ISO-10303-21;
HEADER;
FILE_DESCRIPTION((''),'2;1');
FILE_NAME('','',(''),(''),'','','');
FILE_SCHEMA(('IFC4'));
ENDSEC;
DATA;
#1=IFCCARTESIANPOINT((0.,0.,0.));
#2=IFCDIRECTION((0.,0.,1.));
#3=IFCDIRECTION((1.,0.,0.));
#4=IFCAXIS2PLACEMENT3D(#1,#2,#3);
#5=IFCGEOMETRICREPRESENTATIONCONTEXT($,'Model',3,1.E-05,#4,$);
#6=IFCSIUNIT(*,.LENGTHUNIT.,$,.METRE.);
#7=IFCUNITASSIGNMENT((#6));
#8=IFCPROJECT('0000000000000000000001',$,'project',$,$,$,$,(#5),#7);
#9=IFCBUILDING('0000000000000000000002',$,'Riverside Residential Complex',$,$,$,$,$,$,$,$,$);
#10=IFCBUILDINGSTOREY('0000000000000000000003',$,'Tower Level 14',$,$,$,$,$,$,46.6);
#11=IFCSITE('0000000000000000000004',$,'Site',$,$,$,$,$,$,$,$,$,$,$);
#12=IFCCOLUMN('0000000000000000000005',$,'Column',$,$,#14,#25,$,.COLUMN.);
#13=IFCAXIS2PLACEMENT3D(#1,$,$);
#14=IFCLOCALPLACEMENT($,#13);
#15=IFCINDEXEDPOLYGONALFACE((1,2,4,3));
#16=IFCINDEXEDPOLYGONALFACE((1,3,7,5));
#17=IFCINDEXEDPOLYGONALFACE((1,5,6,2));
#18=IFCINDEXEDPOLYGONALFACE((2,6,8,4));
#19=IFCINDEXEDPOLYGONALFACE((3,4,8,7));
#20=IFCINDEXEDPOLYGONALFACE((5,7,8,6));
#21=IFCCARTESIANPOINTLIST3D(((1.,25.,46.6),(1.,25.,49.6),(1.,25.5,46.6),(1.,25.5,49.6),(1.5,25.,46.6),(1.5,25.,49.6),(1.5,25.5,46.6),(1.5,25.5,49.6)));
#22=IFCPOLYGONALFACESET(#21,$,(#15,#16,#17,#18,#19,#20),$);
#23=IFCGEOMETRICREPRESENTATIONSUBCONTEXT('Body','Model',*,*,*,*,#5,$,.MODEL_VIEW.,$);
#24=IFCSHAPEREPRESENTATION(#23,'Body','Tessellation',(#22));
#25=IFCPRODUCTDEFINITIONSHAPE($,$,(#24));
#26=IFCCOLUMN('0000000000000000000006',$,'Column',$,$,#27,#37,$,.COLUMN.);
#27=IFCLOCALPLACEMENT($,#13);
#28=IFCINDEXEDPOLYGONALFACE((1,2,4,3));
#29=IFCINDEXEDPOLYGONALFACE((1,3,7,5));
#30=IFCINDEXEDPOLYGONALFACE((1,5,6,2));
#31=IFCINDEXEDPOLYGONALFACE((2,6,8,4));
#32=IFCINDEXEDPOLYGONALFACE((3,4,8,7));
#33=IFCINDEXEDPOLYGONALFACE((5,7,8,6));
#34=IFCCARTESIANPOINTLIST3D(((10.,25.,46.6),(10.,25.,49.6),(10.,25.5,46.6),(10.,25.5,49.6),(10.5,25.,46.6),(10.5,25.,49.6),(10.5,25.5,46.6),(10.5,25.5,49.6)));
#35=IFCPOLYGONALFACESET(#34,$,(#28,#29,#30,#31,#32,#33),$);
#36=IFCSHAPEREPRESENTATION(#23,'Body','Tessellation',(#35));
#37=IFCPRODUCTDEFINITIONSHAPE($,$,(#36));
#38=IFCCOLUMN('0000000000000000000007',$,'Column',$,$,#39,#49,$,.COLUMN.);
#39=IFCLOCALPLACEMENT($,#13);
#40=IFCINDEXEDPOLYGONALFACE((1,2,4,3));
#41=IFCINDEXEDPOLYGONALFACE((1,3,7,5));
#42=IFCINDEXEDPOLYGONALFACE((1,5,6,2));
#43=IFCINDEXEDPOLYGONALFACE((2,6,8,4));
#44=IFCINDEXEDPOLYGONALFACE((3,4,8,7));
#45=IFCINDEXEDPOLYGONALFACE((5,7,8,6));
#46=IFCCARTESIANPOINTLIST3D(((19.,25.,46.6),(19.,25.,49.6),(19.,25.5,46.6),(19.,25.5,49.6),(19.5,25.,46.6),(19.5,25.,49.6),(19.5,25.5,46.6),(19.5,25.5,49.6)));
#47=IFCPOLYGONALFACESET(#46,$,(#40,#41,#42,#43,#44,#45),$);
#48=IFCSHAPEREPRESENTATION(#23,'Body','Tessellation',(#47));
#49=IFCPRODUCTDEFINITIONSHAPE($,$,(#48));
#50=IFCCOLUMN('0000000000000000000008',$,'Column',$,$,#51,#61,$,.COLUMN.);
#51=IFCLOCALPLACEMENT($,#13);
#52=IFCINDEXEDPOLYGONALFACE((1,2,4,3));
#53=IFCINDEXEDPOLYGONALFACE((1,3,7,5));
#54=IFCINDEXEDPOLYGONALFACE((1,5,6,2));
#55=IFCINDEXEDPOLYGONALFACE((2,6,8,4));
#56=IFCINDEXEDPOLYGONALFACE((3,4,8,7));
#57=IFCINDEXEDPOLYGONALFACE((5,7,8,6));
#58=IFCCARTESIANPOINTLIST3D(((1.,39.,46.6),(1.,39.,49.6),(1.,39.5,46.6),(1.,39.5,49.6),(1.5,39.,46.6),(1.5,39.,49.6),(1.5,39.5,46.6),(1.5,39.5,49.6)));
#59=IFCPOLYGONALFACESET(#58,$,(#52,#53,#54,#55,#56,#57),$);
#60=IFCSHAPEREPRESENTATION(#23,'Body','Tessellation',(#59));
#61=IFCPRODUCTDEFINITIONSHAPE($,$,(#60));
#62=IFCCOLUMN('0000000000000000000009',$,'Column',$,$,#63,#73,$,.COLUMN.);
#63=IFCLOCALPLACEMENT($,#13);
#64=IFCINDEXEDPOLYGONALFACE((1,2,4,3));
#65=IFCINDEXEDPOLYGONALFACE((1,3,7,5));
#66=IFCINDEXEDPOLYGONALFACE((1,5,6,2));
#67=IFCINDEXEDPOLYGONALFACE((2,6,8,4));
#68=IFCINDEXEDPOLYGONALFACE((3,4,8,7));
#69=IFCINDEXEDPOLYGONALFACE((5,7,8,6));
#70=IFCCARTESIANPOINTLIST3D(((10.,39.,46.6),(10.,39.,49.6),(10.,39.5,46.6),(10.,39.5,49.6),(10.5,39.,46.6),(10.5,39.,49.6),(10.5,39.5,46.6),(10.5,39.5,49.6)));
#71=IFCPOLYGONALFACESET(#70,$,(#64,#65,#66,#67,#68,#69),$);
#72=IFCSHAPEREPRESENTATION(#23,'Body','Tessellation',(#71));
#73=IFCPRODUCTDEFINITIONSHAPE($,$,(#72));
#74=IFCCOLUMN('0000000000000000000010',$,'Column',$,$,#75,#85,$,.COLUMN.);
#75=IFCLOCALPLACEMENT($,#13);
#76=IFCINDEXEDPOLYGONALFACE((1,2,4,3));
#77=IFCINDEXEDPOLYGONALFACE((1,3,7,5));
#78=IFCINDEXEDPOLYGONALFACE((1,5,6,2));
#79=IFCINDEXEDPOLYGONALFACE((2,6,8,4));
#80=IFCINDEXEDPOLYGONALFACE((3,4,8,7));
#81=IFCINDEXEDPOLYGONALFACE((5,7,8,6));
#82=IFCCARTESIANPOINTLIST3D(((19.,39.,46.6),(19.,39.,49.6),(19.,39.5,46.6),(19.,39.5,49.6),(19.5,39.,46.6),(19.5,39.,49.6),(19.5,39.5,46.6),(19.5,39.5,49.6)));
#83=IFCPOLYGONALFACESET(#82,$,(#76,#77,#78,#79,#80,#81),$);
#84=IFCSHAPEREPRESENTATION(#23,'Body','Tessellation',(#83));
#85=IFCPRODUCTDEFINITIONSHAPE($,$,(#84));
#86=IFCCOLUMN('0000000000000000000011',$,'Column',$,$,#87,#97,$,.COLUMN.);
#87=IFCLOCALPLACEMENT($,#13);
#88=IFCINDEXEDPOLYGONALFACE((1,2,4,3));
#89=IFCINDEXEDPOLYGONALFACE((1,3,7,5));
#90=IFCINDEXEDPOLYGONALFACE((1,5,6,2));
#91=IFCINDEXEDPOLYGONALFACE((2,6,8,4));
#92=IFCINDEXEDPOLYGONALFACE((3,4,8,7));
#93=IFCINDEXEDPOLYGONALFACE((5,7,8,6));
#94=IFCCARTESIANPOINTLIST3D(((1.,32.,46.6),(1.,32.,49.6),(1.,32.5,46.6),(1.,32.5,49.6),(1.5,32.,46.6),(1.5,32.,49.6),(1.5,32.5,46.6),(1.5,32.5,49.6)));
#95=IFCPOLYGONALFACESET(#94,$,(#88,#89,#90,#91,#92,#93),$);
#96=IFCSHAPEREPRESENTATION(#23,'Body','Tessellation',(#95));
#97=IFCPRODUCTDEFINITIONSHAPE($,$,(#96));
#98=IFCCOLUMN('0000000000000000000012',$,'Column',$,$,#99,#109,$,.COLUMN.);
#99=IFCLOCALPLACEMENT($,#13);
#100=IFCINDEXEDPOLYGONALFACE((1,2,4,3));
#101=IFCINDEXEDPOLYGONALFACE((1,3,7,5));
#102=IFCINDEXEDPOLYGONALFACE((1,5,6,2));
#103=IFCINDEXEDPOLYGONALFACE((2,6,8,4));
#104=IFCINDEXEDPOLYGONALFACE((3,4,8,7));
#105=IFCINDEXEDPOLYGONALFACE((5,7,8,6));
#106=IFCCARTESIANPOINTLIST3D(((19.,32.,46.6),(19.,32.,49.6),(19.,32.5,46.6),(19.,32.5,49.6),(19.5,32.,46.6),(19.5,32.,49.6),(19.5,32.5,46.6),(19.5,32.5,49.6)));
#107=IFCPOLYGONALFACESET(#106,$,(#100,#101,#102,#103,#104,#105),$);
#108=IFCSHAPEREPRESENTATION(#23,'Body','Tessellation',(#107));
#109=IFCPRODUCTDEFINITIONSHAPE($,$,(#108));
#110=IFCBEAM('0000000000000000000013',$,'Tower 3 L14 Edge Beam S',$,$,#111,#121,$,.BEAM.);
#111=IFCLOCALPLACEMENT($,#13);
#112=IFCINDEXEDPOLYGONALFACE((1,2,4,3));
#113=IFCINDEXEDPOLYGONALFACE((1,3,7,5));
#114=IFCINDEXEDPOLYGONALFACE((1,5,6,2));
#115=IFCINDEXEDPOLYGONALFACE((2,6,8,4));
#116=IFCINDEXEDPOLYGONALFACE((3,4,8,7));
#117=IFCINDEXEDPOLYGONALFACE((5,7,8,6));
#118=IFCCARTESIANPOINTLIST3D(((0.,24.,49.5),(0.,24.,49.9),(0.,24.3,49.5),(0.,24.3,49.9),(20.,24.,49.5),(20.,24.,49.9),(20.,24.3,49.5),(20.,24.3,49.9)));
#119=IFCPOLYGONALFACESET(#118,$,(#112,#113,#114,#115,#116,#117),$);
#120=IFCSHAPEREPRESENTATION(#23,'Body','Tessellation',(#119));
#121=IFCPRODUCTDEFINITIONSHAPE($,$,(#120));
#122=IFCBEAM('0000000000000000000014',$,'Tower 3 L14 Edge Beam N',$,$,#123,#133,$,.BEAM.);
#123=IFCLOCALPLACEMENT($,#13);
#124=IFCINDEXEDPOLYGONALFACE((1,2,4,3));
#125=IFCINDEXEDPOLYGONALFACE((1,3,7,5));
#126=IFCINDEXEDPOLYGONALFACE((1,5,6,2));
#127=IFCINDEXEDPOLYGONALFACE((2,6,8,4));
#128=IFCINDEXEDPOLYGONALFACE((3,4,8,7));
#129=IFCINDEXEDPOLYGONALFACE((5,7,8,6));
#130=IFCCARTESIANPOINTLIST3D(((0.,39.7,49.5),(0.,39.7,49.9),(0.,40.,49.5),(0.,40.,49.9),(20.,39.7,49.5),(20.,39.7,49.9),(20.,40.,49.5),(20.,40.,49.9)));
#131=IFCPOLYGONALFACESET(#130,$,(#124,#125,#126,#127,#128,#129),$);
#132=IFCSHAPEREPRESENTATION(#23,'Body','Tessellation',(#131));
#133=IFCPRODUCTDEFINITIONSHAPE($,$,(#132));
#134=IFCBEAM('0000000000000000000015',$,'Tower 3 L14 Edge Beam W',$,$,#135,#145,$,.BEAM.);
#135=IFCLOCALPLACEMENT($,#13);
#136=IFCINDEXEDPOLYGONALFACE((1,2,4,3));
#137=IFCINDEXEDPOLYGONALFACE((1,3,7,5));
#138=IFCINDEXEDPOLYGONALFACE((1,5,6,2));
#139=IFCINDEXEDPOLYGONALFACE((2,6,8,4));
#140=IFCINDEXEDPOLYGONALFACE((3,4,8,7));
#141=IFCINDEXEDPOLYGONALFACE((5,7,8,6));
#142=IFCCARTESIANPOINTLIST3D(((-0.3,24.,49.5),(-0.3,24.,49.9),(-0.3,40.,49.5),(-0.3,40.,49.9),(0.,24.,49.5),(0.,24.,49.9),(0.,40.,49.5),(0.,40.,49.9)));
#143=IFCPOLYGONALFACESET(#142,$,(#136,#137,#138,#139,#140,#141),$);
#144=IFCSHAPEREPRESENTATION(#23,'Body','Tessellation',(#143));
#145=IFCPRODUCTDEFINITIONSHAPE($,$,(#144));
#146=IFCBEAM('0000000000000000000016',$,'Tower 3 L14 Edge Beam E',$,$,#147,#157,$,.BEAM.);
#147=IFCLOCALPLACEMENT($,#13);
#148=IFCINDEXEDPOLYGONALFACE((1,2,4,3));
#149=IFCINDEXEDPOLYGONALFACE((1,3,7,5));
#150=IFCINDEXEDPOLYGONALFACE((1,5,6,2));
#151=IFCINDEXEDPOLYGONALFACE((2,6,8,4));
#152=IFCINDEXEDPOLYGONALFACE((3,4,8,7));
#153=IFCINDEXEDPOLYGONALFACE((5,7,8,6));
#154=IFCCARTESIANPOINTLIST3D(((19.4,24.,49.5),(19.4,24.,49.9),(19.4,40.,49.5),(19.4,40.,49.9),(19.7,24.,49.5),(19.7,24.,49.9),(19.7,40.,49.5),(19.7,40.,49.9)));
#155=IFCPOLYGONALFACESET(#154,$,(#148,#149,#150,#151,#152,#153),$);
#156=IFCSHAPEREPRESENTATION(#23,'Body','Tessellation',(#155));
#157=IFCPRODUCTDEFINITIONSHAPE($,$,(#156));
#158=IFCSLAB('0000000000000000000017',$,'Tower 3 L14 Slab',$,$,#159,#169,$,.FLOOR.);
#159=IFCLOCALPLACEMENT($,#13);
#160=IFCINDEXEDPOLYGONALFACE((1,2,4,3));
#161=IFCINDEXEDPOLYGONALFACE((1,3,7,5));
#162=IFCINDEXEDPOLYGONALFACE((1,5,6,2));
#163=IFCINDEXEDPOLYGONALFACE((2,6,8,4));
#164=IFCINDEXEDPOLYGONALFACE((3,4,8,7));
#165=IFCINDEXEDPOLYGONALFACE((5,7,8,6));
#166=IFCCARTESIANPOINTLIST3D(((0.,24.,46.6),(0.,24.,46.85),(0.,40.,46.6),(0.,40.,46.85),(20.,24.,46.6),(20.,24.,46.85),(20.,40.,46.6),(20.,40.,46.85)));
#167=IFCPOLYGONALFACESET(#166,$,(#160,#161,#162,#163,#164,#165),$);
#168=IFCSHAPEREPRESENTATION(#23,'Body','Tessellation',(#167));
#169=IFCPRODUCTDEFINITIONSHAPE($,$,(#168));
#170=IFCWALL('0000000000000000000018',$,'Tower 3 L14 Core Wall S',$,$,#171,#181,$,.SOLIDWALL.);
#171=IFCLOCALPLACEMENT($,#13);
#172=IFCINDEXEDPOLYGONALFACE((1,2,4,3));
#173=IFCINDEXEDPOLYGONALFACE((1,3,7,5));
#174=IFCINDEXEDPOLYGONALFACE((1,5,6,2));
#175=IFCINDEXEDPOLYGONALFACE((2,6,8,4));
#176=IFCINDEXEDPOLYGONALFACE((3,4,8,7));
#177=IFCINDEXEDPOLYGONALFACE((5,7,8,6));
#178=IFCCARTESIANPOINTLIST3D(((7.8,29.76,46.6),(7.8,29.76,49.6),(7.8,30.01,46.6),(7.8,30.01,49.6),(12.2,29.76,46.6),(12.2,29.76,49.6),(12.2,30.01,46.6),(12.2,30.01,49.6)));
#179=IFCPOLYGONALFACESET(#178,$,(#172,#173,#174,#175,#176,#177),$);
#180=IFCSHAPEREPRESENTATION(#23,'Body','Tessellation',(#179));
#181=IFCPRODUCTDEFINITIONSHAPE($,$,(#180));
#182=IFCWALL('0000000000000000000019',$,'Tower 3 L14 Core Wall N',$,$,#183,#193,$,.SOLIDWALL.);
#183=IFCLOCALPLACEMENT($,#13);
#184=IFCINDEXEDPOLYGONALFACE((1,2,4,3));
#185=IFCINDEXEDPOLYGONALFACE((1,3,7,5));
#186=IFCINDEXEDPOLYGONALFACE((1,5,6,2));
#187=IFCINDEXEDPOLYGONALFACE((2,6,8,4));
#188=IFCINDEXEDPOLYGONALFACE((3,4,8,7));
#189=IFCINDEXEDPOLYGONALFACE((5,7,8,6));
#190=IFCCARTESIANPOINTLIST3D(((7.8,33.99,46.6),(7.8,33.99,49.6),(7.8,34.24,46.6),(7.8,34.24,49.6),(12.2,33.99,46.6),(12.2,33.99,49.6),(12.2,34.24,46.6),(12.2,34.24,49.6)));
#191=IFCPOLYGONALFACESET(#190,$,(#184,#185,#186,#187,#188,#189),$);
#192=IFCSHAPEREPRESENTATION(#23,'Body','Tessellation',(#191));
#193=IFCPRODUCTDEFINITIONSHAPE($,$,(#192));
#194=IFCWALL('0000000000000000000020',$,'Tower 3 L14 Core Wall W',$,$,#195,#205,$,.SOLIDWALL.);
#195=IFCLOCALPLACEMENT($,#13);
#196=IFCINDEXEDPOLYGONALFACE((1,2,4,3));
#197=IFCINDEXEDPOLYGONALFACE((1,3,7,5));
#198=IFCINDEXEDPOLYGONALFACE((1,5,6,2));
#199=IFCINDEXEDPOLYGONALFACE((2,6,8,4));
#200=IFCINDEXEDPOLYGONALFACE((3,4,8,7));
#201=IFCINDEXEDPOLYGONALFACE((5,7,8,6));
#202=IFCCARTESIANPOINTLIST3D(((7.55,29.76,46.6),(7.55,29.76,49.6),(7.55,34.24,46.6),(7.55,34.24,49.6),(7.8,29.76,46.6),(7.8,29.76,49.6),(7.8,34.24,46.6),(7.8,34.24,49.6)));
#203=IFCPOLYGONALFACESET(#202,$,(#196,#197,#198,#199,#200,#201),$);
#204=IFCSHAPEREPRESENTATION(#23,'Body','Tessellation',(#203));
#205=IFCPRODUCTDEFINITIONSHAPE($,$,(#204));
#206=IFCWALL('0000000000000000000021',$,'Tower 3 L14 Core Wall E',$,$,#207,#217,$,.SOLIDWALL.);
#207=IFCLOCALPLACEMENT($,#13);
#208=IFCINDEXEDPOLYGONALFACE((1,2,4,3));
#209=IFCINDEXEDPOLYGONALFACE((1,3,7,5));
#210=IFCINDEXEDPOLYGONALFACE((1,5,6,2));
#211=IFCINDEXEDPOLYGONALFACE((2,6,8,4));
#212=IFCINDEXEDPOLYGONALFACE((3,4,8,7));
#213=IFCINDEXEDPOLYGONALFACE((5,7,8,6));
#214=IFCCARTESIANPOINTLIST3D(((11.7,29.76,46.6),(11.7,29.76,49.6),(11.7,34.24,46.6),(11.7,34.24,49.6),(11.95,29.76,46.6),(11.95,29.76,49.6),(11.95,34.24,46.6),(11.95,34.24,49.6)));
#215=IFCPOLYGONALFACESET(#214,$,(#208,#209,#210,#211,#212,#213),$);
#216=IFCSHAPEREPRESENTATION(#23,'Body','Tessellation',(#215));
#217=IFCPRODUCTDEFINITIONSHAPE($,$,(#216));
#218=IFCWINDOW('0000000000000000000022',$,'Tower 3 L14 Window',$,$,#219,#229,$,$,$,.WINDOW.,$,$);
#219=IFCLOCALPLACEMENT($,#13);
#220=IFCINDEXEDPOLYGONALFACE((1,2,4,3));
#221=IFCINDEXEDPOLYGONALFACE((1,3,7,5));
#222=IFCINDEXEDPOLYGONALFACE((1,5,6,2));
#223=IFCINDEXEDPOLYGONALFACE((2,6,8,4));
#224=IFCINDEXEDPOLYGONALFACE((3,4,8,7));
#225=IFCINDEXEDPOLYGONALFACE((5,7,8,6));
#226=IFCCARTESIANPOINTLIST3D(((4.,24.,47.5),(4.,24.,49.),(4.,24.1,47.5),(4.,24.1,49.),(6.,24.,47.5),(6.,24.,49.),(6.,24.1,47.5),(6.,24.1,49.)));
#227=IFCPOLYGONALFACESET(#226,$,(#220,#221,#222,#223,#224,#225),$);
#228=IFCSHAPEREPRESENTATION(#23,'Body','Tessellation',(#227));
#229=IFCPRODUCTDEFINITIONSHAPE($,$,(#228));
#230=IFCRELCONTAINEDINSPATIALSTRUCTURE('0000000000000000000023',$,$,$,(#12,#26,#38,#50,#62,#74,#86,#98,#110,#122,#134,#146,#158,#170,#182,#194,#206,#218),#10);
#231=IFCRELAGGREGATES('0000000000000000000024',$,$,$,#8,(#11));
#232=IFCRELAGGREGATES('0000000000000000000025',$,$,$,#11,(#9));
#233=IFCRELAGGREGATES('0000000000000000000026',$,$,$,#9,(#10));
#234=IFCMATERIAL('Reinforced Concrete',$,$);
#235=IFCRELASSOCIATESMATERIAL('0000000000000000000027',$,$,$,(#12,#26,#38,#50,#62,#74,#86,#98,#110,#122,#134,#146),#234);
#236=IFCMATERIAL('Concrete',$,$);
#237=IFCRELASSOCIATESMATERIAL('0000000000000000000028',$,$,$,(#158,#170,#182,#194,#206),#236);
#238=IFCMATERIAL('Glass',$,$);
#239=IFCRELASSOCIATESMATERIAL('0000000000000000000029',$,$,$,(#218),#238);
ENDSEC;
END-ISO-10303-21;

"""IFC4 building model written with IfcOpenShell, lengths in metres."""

from ifc_helpers import new_model, si_unit, frame, origin_with_axes, place, context, subcontext, project, spatial, line, indexed_curve, outline, extrude, material, element, save


model = new_model("IFC4")

# Units and contexts
model_context = context("Model", 3, precision=1e-05, world=origin_with_axes())
body_context = subcontext(model_context, "Body", "Model", "MODEL_VIEW")
ifc_project = project(units=[si_unit("LENGTHUNIT", "METRE")], contexts=[model_context])

# Site, building, storey
site = spatial("IfcSite", under=ifc_project, Name="Site")
building = spatial("IfcBuilding", under=site, Name="Riverside Residential Complex")
storey = spatial("IfcBuildingStorey", under=building, Name="Tower Level 14", Elevation=46.6)

# Columns
ifc_material_1 = material(Name="Reinforced Concrete")
for number, where, z_axis, x_axis, name in (
    (1, (1.0, 25.0, 46.6), (0.0, 0.0, 1.0), (1.0, 0.0, 0.0), "Column"),
    (2, (10.0, 25.0, 46.6), (0.0, 0.0, 1.0), (1.0, 0.0, 0.0), "Column"),
    (3, (19.0, 25.0, 46.6), (0.0, 0.0, 1.0), (1.0, 0.0, 0.0), "Column"),
    (4, (1.0, 39.0, 46.6), (0.0, 0.0, 1.0), (1.0, 0.0, 0.0), "Column"),
    (5, (10.0, 39.0, 46.6), (0.0, 0.0, 1.0), (1.0, 0.0, 0.0), "Column"),
    (6, (19.0, 39.0, 46.6), (0.0, 0.0, 1.0), (1.0, 0.0, 0.0), "Column"),
    (7, (1.0, 32.0, 46.6), (0.0, 0.0, 1.0), (1.0, 0.0, 0.0), "Column"),
    (8, (19.0, 32.0, 46.6), (0.0, 0.0, 1.0), (1.0, 0.0, 0.0), "Column"),
):
    element("IfcColumn", number, at=place(None, frame(where, z_axis=z_axis, x_axis=x_axis)), inside=storey, material=ifc_material_1, Name=name, PredefinedType="COLUMN", context=body_context, shape_type="SweptSolid", body=[
        extrude(outline(indexed_curve([(0.0, 0.0), (0.5, 0.0), (0.5, 0.5), (0.0, 0.5)], segments=[line(1, 2, 3, 4, 1)])), origin_with_axes(), (0.0, 0.0, 1.0), 3.0),
    ])

# Beams
for number, where, z_axis, x_axis, name in (
    (9, (0.0, 24.0, 49.5), (0.0, 0.0, 1.0), (1.0, 0.0, 0.0), "Tower 3 L14 Edge Beam S"),
    (10, (0.0, 39.7, 49.5), (0.0, 0.0, 1.0), (1.0, 0.0, 0.0), "Tower 3 L14 Edge Beam N"),
):
    element("IfcBeam", number, at=place(None, frame(where, z_axis=z_axis, x_axis=x_axis)), inside=storey, material=ifc_material_1, Name=name, PredefinedType="BEAM", context=body_context, shape_type="SweptSolid", body=[
        extrude(outline(indexed_curve([(0.0, 0.0), (20.0, 0.0), (20.0, 0.3), (0.0, 0.3)], segments=[line(1, 2, 3, 4, 1)])), origin_with_axes(), (0.0, 0.0, 1.0), 0.4),
    ])
for number, where, z_axis, x_axis, name in (
    (11, (0.0, 24.0, 49.5), (0.0, 0.0, 1.0), (0.0, 1.0, 0.0), "Tower 3 L14 Edge Beam W"),
    (12, (19.7, 24.0, 49.5), (0.0, 0.0, 1.0), (0.0, 1.0, 0.0), "Tower 3 L14 Edge Beam E"),
):
    element("IfcBeam", number, at=place(None, frame(where, z_axis=z_axis, x_axis=x_axis)), inside=storey, material=ifc_material_1, Name=name, PredefinedType="BEAM", context=body_context, shape_type="SweptSolid", body=[
        extrude(outline(indexed_curve([(0.0, 0.0), (16.0, 0.0), (16.0, 0.3), (0.0, 0.3)], segments=[line(1, 2, 3, 4, 1)])), origin_with_axes(), (0.0, 0.0, 1.0), 0.4),
    ])

# Slab
ifc_material_2 = material(Name="Concrete")
slab_placement = place(None, frame((0.0, 24.0, 46.6), z_axis=(0.0, 0.0, 1.0), x_axis=(1.0, 0.0, 0.0)))
element("IfcSlab", 13, at=slab_placement, inside=storey, material=ifc_material_2, Name="Tower 3 L14 Slab", PredefinedType="FLOOR", context=body_context, shape_type="SweptSolid", body=[
    extrude(outline(indexed_curve([(0.0, 0.0), (20.0, 0.0), (20.0, 16.0), (0.0, 16.0)], segments=[line(1, 2, 3, 4, 1)])), origin_with_axes(), (0.0, 0.0, 1.0), 0.25),
])

# Walls
for number, where, z_axis, x_axis, name in (
    (14, (7.8, 29.76, 46.6), (0.0, 0.0, 1.0), (1.0, 0.0, 0.0), "Tower 3 L14 Core Wall S"),
    (15, (7.8, 33.99, 46.6), (0.0, 0.0, 1.0), (1.0, 0.0, 0.0), "Tower 3 L14 Core Wall N"),
):
    element("IfcWall", number, at=place(None, frame(where, z_axis=z_axis, x_axis=x_axis)), inside=storey, material=ifc_material_2, Name=name, PredefinedType="SOLIDWALL", context=body_context, shape_type="SweptSolid", body=[
        extrude(outline(indexed_curve([(0.0, 0.0), (4.4, 0.0), (4.4, 0.25), (0.0, 0.25)], segments=[line(1, 2, 3, 4, 1)])), origin_with_axes(), (0.0, 0.0, 1.0), 3.0),
    ])
for number, where, z_axis, x_axis, name in (
    (16, (7.8, 29.76, 46.6), (0.0, 0.0, 1.0), (0.0, 1.0, 0.0), "Tower 3 L14 Core Wall W"),
    (17, (11.95, 29.76, 46.6), (0.0, 0.0, 1.0), (0.0, 1.0, 0.0), "Tower 3 L14 Core Wall E"),
):
    element("IfcWall", number, at=place(None, frame(where, z_axis=z_axis, x_axis=x_axis)), inside=storey, material=ifc_material_2, Name=name, PredefinedType="SOLIDWALL", context=body_context, shape_type="SweptSolid", body=[
        extrude(outline(indexed_curve([(0.0, 0.0), (4.48, 0.0), (4.48, 0.25), (0.0, 0.25)], segments=[line(1, 2, 3, 4, 1)])), origin_with_axes(), (0.0, 0.0, 1.0), 3.0),
    ])

# Window
ifc_material_3 = material(Name="Glass")
for number, where, z_axis, x_axis, name in (
    (18, (4.0, 24.0, 47.5), (0.0, 0.0, 1.0), (1.0, 0.0, 0.0), "Tower 3 L14 Window"),
):
    element("IfcWindow", number, at=place(None, frame(where, z_axis=z_axis, x_axis=x_axis)), inside=storey, material=ifc_material_3, Name=name, PredefinedType="WINDOW", context=body_context, shape_type="SweptSolid", body=[
        extrude(outline(indexed_curve([(0.0, 0.0), (2.0, 0.0), (2.0, 0.1), (0.0, 0.1)], segments=[line(1, 2, 3, 4, 1)])), origin_with_axes(), (0.0, 0.0, 1.0), 1.5),
    ])

save(model, "model.ifc")
